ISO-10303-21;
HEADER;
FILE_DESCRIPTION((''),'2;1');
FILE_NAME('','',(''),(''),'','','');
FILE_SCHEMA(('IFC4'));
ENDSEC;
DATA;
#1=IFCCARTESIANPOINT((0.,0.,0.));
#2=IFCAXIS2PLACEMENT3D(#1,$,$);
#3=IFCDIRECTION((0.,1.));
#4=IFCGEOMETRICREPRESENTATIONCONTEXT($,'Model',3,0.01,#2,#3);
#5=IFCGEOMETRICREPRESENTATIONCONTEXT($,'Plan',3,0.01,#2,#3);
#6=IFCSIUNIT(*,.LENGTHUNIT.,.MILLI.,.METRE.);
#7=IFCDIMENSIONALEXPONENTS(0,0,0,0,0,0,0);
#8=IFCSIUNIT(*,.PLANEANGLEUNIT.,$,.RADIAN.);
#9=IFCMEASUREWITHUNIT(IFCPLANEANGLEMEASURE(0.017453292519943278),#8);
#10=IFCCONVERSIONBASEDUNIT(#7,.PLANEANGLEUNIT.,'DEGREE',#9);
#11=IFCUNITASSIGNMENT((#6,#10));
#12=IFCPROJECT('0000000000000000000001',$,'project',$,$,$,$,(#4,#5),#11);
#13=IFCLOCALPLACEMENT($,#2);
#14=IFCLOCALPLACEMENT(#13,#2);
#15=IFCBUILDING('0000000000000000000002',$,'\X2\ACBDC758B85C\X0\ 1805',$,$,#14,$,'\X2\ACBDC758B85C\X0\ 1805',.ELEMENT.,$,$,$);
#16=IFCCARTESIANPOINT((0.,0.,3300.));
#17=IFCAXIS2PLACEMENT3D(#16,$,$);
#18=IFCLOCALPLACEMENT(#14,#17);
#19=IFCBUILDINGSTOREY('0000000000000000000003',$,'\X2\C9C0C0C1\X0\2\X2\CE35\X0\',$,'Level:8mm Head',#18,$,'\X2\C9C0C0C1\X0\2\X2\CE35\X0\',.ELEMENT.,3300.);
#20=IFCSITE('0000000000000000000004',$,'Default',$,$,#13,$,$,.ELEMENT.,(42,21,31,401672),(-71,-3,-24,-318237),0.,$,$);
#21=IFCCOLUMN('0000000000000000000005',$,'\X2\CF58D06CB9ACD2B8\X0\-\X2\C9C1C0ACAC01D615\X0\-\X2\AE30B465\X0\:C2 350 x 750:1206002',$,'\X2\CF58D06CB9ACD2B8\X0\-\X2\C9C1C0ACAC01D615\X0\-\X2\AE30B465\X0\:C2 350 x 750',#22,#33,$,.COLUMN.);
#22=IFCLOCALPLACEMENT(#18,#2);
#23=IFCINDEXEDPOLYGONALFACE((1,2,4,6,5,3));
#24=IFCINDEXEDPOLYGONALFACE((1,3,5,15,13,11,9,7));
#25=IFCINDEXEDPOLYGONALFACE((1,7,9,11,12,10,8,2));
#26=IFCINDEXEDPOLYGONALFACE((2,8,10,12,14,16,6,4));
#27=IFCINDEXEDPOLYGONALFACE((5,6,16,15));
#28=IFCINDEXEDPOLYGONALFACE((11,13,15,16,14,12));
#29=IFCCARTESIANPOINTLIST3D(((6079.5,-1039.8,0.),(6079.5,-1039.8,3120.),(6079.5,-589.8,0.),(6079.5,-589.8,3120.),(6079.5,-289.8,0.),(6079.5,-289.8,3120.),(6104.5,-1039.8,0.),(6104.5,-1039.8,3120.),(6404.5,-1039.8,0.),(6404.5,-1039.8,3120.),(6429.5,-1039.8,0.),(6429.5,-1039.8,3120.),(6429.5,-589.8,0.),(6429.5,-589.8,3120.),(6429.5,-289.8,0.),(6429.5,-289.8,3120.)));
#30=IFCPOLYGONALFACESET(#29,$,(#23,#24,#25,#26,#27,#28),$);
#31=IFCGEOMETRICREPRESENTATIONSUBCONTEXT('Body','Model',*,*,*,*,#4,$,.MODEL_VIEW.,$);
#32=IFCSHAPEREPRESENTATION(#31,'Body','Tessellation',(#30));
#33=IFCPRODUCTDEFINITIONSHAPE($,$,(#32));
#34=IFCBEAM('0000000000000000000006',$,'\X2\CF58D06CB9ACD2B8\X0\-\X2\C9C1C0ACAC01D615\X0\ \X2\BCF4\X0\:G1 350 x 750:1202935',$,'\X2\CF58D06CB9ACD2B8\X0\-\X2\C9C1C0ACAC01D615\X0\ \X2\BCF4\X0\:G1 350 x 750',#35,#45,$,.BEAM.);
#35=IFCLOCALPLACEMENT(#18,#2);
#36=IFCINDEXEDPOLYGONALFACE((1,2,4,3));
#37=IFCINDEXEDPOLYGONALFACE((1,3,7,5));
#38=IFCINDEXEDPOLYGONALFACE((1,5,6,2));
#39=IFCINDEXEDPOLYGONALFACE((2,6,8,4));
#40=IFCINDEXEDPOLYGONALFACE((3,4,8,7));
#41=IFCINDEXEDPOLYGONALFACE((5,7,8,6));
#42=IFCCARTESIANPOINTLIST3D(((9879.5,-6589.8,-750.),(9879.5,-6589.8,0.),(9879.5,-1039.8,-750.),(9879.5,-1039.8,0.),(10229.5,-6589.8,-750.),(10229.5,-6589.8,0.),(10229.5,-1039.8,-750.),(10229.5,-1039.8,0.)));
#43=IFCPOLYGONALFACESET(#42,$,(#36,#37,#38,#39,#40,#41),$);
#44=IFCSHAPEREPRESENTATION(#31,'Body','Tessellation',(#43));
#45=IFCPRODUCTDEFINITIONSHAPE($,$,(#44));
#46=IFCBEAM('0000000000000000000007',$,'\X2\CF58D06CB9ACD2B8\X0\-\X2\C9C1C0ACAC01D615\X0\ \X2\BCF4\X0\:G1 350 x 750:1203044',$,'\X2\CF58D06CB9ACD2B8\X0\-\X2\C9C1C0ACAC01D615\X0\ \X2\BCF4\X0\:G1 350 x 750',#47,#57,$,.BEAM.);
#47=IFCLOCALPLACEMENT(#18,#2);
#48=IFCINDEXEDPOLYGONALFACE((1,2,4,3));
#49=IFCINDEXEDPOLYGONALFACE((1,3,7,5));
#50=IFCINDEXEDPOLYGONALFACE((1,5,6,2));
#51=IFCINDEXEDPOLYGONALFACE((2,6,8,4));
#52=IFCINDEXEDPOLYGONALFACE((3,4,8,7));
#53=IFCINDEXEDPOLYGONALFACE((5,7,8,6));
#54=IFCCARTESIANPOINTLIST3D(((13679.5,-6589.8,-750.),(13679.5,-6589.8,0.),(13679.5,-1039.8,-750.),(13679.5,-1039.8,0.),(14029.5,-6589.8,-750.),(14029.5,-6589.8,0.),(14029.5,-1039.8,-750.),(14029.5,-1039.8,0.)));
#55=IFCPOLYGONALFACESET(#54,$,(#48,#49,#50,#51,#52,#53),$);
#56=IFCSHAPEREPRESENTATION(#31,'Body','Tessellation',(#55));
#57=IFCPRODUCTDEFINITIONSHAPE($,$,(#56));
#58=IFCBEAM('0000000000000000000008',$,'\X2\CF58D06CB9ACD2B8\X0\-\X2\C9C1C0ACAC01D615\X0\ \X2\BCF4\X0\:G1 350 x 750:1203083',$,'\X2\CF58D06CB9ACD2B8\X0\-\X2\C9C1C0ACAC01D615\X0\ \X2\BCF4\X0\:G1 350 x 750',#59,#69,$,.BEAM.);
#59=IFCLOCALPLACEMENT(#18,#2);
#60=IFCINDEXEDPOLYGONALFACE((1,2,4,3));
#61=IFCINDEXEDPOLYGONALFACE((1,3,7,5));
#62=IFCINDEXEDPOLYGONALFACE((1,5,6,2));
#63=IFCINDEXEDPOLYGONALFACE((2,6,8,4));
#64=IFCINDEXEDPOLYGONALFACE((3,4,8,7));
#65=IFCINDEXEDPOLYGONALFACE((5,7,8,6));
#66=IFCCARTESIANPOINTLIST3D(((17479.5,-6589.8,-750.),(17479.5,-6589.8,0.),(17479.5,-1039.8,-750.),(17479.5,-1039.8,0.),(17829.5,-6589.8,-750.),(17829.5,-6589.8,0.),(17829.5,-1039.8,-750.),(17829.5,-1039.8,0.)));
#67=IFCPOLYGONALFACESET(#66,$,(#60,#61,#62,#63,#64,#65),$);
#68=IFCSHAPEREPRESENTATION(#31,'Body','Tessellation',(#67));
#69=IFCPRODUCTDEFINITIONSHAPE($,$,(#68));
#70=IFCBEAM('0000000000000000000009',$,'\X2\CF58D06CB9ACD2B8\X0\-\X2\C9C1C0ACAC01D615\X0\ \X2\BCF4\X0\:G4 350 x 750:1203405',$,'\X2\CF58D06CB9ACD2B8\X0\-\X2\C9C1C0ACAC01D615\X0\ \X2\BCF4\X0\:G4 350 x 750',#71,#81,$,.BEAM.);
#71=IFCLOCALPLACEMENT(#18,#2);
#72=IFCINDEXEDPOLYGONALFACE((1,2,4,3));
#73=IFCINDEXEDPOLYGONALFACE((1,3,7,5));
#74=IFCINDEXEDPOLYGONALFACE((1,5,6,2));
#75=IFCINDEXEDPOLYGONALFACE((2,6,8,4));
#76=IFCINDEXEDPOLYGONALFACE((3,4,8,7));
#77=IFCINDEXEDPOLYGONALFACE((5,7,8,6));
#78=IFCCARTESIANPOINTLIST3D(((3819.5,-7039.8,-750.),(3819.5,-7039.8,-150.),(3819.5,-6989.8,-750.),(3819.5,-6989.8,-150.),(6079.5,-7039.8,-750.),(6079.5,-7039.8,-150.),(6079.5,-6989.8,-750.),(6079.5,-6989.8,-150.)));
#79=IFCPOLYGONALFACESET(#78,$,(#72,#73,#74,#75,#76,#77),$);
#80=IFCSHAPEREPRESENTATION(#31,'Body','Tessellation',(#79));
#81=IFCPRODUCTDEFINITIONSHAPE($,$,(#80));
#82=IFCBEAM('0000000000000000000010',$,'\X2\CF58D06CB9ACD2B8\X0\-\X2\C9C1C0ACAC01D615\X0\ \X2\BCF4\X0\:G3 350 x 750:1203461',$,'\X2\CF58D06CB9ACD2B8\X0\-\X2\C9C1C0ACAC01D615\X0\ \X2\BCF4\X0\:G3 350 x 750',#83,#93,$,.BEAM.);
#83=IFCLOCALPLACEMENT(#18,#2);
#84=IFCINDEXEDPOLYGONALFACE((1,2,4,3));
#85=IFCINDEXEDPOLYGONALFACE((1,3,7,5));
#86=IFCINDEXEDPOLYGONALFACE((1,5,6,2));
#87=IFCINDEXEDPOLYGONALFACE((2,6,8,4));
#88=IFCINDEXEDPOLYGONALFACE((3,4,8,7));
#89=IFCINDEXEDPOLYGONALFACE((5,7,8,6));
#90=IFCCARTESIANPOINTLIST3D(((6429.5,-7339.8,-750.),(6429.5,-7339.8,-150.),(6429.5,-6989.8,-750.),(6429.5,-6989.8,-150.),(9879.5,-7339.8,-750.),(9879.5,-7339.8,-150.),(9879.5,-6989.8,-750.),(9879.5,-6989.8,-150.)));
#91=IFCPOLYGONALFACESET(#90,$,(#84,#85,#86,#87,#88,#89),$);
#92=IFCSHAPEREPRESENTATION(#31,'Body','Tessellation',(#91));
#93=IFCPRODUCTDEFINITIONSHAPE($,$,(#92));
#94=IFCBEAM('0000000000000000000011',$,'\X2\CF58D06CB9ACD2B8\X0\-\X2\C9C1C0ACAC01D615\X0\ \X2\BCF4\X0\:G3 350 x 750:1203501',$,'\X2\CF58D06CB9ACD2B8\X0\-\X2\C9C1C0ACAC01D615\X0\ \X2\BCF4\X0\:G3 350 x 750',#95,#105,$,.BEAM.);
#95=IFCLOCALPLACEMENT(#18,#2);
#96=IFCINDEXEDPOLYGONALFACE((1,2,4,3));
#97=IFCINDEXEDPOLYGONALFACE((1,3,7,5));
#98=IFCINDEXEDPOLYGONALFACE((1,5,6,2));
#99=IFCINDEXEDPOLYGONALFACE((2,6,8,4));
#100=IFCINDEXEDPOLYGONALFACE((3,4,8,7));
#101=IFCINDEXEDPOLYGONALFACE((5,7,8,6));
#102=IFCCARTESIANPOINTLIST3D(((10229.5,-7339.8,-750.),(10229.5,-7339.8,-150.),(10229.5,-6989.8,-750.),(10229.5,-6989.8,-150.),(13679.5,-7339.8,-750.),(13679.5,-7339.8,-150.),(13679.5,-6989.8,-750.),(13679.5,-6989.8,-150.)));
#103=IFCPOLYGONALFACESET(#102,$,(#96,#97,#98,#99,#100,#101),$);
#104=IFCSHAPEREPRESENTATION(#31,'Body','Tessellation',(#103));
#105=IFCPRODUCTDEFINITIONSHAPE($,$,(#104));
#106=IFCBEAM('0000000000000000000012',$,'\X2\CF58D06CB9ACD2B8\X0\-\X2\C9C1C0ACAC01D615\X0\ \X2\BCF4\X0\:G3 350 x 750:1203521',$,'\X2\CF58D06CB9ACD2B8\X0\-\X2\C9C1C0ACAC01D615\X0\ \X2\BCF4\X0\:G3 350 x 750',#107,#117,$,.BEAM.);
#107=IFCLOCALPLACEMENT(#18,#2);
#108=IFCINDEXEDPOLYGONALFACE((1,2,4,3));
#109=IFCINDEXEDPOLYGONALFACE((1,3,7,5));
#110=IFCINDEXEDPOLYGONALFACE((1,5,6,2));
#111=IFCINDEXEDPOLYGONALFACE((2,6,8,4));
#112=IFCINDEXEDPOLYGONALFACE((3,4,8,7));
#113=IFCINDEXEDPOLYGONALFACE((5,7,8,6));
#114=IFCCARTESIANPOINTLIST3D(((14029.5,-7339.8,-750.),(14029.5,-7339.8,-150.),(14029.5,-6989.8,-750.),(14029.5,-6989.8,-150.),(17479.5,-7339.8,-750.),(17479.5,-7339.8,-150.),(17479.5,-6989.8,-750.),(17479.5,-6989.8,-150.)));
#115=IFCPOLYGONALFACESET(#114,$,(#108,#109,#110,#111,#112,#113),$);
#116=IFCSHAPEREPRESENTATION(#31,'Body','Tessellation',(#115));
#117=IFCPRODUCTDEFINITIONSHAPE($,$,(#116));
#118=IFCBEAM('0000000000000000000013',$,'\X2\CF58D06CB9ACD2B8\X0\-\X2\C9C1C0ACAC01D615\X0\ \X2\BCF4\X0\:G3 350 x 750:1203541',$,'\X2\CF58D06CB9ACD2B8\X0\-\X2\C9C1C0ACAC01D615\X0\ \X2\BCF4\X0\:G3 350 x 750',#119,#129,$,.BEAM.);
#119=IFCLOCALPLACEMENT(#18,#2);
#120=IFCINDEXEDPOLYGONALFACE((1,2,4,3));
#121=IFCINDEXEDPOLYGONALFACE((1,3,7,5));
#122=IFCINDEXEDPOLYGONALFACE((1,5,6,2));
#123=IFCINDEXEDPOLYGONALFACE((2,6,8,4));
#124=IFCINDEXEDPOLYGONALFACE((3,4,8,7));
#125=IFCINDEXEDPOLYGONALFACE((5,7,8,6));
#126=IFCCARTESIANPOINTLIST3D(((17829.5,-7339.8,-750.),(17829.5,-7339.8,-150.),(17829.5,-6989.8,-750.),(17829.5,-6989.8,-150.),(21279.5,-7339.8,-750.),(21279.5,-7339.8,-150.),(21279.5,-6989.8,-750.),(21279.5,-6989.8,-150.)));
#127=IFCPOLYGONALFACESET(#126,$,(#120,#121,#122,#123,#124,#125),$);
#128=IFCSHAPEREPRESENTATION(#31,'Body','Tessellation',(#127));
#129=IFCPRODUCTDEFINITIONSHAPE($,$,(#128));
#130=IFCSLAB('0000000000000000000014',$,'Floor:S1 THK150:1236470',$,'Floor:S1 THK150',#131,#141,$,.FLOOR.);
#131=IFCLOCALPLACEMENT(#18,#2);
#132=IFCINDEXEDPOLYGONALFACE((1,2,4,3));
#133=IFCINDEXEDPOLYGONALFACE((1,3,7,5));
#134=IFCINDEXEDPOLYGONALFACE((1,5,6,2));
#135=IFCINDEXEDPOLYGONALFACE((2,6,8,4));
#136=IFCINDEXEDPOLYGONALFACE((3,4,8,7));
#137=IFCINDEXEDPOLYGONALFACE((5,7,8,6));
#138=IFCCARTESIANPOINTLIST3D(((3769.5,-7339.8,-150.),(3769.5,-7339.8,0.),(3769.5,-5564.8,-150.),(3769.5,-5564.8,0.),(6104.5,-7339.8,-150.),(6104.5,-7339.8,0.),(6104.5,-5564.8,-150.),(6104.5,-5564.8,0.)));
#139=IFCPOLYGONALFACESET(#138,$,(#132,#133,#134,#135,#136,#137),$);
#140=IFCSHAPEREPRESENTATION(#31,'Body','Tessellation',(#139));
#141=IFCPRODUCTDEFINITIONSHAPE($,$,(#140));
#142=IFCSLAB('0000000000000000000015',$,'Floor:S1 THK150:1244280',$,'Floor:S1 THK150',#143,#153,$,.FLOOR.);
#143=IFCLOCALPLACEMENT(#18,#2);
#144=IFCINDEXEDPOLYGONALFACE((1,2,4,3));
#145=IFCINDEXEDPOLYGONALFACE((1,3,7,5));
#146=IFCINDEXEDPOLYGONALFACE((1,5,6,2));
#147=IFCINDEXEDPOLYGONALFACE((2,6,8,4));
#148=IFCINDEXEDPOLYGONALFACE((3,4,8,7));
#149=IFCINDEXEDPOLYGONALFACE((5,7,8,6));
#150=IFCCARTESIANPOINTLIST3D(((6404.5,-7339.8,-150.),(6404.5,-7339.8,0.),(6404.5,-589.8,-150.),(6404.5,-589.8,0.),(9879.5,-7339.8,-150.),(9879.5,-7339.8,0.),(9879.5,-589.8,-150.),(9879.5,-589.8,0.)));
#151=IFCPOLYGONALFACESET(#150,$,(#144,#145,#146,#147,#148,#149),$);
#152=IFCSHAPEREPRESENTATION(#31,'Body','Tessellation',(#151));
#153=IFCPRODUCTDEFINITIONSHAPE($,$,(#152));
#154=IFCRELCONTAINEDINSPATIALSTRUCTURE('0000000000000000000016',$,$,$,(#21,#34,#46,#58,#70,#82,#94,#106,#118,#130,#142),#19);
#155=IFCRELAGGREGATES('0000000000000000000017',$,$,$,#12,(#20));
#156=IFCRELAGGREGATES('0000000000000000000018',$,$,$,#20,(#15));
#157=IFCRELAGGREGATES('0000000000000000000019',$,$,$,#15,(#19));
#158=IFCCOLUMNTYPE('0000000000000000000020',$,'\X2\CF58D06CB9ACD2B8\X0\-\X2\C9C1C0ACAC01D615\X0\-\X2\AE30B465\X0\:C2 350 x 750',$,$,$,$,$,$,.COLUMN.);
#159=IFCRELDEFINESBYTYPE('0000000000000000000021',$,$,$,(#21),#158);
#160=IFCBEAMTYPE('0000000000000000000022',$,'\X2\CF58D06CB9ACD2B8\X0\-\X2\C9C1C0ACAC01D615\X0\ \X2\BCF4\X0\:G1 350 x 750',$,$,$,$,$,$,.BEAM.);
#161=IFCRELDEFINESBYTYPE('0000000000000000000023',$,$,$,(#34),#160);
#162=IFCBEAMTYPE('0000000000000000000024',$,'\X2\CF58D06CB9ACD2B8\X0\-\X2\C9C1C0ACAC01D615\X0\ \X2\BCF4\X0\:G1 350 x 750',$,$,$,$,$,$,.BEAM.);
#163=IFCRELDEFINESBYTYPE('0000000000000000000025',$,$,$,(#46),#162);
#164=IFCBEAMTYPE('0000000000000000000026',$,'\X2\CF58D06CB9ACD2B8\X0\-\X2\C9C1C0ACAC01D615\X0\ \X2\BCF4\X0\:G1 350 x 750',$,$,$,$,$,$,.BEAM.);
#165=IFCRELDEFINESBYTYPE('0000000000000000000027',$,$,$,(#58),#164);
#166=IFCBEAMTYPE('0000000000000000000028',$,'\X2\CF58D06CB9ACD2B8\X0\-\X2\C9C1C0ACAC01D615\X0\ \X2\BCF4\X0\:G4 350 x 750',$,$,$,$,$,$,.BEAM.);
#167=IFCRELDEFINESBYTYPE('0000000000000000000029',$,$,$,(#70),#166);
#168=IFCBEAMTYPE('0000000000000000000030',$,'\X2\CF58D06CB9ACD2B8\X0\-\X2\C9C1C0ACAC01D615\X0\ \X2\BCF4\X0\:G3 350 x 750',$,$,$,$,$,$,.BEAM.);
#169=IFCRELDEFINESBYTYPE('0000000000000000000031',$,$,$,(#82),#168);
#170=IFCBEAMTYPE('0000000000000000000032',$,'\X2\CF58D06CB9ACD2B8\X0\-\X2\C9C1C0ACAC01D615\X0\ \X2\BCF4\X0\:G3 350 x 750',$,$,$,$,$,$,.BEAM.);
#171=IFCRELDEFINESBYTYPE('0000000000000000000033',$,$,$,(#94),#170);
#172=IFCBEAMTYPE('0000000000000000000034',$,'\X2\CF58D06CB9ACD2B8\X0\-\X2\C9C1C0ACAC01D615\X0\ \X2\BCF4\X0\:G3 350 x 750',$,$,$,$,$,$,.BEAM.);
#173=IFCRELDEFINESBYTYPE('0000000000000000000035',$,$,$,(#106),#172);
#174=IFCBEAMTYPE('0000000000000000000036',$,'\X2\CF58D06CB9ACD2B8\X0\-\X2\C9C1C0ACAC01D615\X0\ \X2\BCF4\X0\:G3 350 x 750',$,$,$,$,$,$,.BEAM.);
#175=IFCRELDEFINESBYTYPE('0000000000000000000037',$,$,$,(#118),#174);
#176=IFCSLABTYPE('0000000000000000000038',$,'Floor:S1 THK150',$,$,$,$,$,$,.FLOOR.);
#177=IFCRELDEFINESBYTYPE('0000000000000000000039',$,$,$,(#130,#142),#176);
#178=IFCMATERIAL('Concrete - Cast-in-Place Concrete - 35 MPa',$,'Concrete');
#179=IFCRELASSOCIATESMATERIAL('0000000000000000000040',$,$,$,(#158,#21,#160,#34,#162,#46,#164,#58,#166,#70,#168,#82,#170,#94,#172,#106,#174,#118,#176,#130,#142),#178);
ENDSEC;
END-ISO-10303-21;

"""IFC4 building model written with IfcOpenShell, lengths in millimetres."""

from ifc_helpers import new_model, entity, si_unit, converted_unit, direction, frame, origin, place, context, subcontext, project, spatial, indexed_curve, outline, extrude, source, transform, mapped, material, type_object, type_shapes, element, save


model = new_model("IFC4")

# Units and contexts
model_context = context("Model", 3, precision=0.01, world=origin(), true_north=direction((0.0, 1.0)))
plan_context = context("Plan", 3, precision=0.01, world=origin(), true_north=direction((0.0, 1.0)))
body_context = subcontext(model_context, "Body", "Model", "MODEL_VIEW")
ifc_project = project(units=[si_unit("LENGTHUNIT", "METRE", prefix="MILLI"), converted_unit("PLANEANGLEUNIT", "DEGREE", entity("IfcPlaneAngleMeasure", 0.017453292519943278), si_unit("PLANEANGLEUNIT", "RADIAN"), dimensions=[0, 0, 0, 0, 0, 0, 0])], contexts=[model_context, plan_context])

# Site, building, storey
site_placement = place(None, origin())
site = spatial("IfcSite", under=ifc_project, at=site_placement, Name="Default", CompositionType="ELEMENT", RefLatitude=(42, 21, 31, 401672), RefLongitude=(-71, -3, -24, -318237), RefElevation=0.0)
building_placement = place(site_placement, origin())
building = spatial("IfcBuilding", under=site, at=building_placement, Name="경의로 1805", LongName="경의로 1805", CompositionType="ELEMENT")
storey_placement = place(building_placement, frame((0.0, 0.0, 3300.0)))
storey = spatial("IfcBuildingStorey", under=building, at=storey_placement, Name="지상2층", ObjectType="Level:8mm Head", LongName="지상2층", CompositionType="ELEMENT", Elevation=3300.0)

# Column
ifc_material_1 = material(Name="Concrete - Cast-in-Place Concrete - 35 MPa", Category="Concrete")
column_type_1 = type_object("IfcColumnType", Name="콘크리트-직사각형-기둥:C2 350 x 750", PredefinedType="COLUMN", material=ifc_material_1)
shared_shape_1 = source(origin(), body_context, "Body", "SweptSolid", [
    extrude(outline(indexed_curve([(-175.0, -450.0), (175.0, -450.0), (175.0, -150.0), (175.0, 300.0), (150.0, 300.0), (-150.0, 300.0), (-175.0, 300.0), (-175.0, -150.0), (-175.0, -450.0)], self_intersect=False)), frame((6254.5, -739.8, 3300.0), z_axis=(0.0, 0.0, 1.0), x_axis=(-1.0, 0.0, 0.0)), (0.0, 0.0, 1.0), 3120.0),
])
type_shapes(column_type_1, [shared_shape_1])
column_1_placement = place(storey_placement, frame((0.0, 0.0, -3300.0)))
element("IfcColumn", 1, at=column_1_placement, inside=storey, type_object=column_type_1, material=ifc_material_1, Name="콘크리트-직사각형-기둥:C2 350 x 750:1206002", ObjectType="콘크리트-직사각형-기둥:C2 350 x 750", PredefinedType="COLUMN", context=body_context, shape_type="MappedRepresentation", body=[
    mapped(shared_shape_1, transform((0.0, 0.0, 0.0), scale=1.0)),
])

# Beams
beam_type_1 = type_object("IfcBeamType", Name="콘크리트-직사각형 보:G1 350 x 750", PredefinedType="BEAM", material=ifc_material_1)
shared_shape_2 = source(origin(), body_context, "Body", "SweptSolid", [
    extrude(outline(indexed_curve([(-175.0, -375.0), (175.0, -375.0), (175.0, 375.0), (-175.0, 375.0), (-175.0, -375.0)], self_intersect=False)), frame((10054.5, -1039.8, 2925.0), z_axis=(0.0, -1.0, 0.0), x_axis=(-1.0, 0.0, 0.0)), (0.0, 0.0, 1.0), 5550.0),
])
type_shapes(beam_type_1, [shared_shape_2])
beam_1_placement = place(storey_placement, frame((0.0, 0.0, -3300.0)))
element("IfcBeam", 2, at=beam_1_placement, inside=storey, type_object=beam_type_1, material=ifc_material_1, Name="콘크리트-직사각형 보:G1 350 x 750:1202935", ObjectType="콘크리트-직사각형 보:G1 350 x 750", PredefinedType="BEAM", context=body_context, shape_type="MappedRepresentation", body=[
    mapped(shared_shape_2, transform((0.0, 0.0, 0.0), scale=1.0)),
])
beam_type_2 = type_object("IfcBeamType", Name="콘크리트-직사각형 보:G1 350 x 750", PredefinedType="BEAM", material=ifc_material_1)
shared_shape_3 = source(origin(), body_context, "Body", "SweptSolid", [
    extrude(outline(indexed_curve([(-175.0, -375.0), (175.0, -375.0), (175.0, 375.0), (-175.0, 375.0), (-175.0, -375.0)], self_intersect=False)), frame((13854.5, -6589.8, 2925.0), z_axis=(0.0, 1.0, 0.0), x_axis=(-1.0, 0.0, 0.0)), (0.0, 0.0, 1.0), 5550.0),
])
type_shapes(beam_type_2, [shared_shape_3])
beam_2_placement = place(storey_placement, frame((0.0, 0.0, -3300.0)))
element("IfcBeam", 3, at=beam_2_placement, inside=storey, type_object=beam_type_2, material=ifc_material_1, Name="콘크리트-직사각형 보:G1 350 x 750:1203044", ObjectType="콘크리트-직사각형 보:G1 350 x 750", PredefinedType="BEAM", context=body_context, shape_type="MappedRepresentation", body=[
    mapped(shared_shape_3, transform((0.0, 0.0, 0.0), scale=1.0)),
])
beam_type_3 = type_object("IfcBeamType", Name="콘크리트-직사각형 보:G1 350 x 750", PredefinedType="BEAM", material=ifc_material_1)
shared_shape_4 = source(origin(), body_context, "Body", "SweptSolid", [
    extrude(outline(indexed_curve([(-175.0, -375.0), (175.0, -375.0), (175.0, 375.0), (-175.0, 375.0), (-175.0, -375.0)], self_intersect=False)), frame((17654.5, -6589.8, 2925.0), z_axis=(0.0, 1.0, 0.0), x_axis=(-1.0, 0.0, 0.0)), (0.0, 0.0, 1.0), 5550.0),
])
type_shapes(beam_type_3, [shared_shape_4])
beam_3_placement = place(storey_placement, frame((0.0, 0.0, -3300.0)))
element("IfcBeam", 4, at=beam_3_placement, inside=storey, type_object=beam_type_3, material=ifc_material_1, Name="콘크리트-직사각형 보:G1 350 x 750:1203083", ObjectType="콘크리트-직사각형 보:G1 350 x 750", PredefinedType="BEAM", context=body_context, shape_type="MappedRepresentation", body=[
    mapped(shared_shape_4, transform((0.0, 0.0, 0.0), scale=1.0)),
])
beam_type_4 = type_object("IfcBeamType", Name="콘크리트-직사각형 보:G4 350 x 750", PredefinedType="BEAM", material=ifc_material_1)
shared_shape_5 = source(origin(), body_context, "Body", "SweptSolid", [
    extrude(outline(indexed_curve([(-300.0, -25.0), (300.0, -25.0), (300.0, 25.0), (-300.0, 25.0), (-300.0, -25.0)], self_intersect=False)), frame((3819.5, -7014.8, 2850.0), z_axis=(1.0, 0.0, 0.0), x_axis=(0.0, 0.0, -1.0)), (0.0, 0.0, 1.0), 2260.0),
])
type_shapes(beam_type_4, [shared_shape_5])
beam_4_placement = place(storey_placement, frame((0.0, 0.0, -3300.0)))
element("IfcBeam", 5, at=beam_4_placement, inside=storey, type_object=beam_type_4, material=ifc_material_1, Name="콘크리트-직사각형 보:G4 350 x 750:1203405", ObjectType="콘크리트-직사각형 보:G4 350 x 750", PredefinedType="BEAM", context=body_context, shape_type="MappedRepresentation", body=[
    mapped(shared_shape_5, transform((0.0, 0.0, 0.0), scale=1.0)),
])
beam_type_5 = type_object("IfcBeamType", Name="콘크리트-직사각형 보:G3 350 x 750", PredefinedType="BEAM", material=ifc_material_1)
shared_shape_6 = source(origin(), body_context, "Body", "SweptSolid", [
    extrude(outline(indexed_curve([(-300.0, -175.0), (300.0, -175.0), (300.0, 175.0), (-300.0, 175.0), (-300.0, -175.0)], self_intersect=False)), frame((6429.5, -7164.8, 2850.0), z_axis=(1.0, 0.0, 0.0), x_axis=(0.0, 0.0, -1.0)), (0.0, 0.0, 1.0), 3450.0),
])
type_shapes(beam_type_5, [shared_shape_6])
beam_5_placement = place(storey_placement, frame((0.0, 0.0, -3300.0)))
element("IfcBeam", 6, at=beam_5_placement, inside=storey, type_object=beam_type_5, material=ifc_material_1, Name="콘크리트-직사각형 보:G3 350 x 750:1203461", ObjectType="콘크리트-직사각형 보:G3 350 x 750", PredefinedType="BEAM", context=body_context, shape_type="MappedRepresentation", body=[
    mapped(shared_shape_6, transform((0.0, 0.0, 0.0), scale=1.0)),
])
beam_type_6 = type_object("IfcBeamType", Name="콘크리트-직사각형 보:G3 350 x 750", PredefinedType="BEAM", material=ifc_material_1)
shared_shape_7 = source(origin(), body_context, "Body", "SweptSolid", [
    extrude(outline(indexed_curve([(-300.0, -175.0), (300.0, -175.0), (300.0, 175.0), (-300.0, 175.0), (-300.0, -175.0)], self_intersect=False)), frame((10229.5, -7164.8, 2850.0), z_axis=(1.0, 0.0, 0.0), x_axis=(0.0, 0.0, -1.0)), (0.0, 0.0, 1.0), 3450.0),
])
type_shapes(beam_type_6, [shared_shape_7])
beam_6_placement = place(storey_placement, frame((0.0, 0.0, -3300.0)))
element("IfcBeam", 7, at=beam_6_placement, inside=storey, type_object=beam_type_6, material=ifc_material_1, Name="콘크리트-직사각형 보:G3 350 x 750:1203501", ObjectType="콘크리트-직사각형 보:G3 350 x 750", PredefinedType="BEAM", context=body_context, shape_type="MappedRepresentation", body=[
    mapped(shared_shape_7, transform((0.0, 0.0, 0.0), scale=1.0)),
])
beam_type_7 = type_object("IfcBeamType", Name="콘크리트-직사각형 보:G3 350 x 750", PredefinedType="BEAM", material=ifc_material_1)
shared_shape_8 = source(origin(), body_context, "Body", "SweptSolid", [
    extrude(outline(indexed_curve([(-300.0, -175.0), (300.0, -175.0), (300.0, 175.0), (-300.0, 175.0), (-300.0, -175.0)], self_intersect=False)), frame((14029.5, -7164.8, 2850.0), z_axis=(1.0, 0.0, 0.0), x_axis=(0.0, 0.0, -1.0)), (0.0, 0.0, 1.0), 3450.0),
])
type_shapes(beam_type_7, [shared_shape_8])
beam_7_placement = place(storey_placement, frame((0.0, 0.0, -3300.0)))
element("IfcBeam", 8, at=beam_7_placement, inside=storey, type_object=beam_type_7, material=ifc_material_1, Name="콘크리트-직사각형 보:G3 350 x 750:1203521", ObjectType="콘크리트-직사각형 보:G3 350 x 750", PredefinedType="BEAM", context=body_context, shape_type="MappedRepresentation", body=[
    mapped(shared_shape_8, transform((0.0, 0.0, 0.0), scale=1.0)),
])
beam_type_8 = type_object("IfcBeamType", Name="콘크리트-직사각형 보:G3 350 x 750", PredefinedType="BEAM", material=ifc_material_1)
shared_shape_9 = source(origin(), body_context, "Body", "SweptSolid", [
    extrude(outline(indexed_curve([(-300.0, -175.0), (300.0, -175.0), (300.0, 175.0), (-300.0, 175.0), (-300.0, -175.0)], self_intersect=False)), frame((17829.5, -7164.8, 2850.0), z_axis=(1.0, 0.0, 0.0), x_axis=(0.0, 0.0, -1.0)), (0.0, 0.0, 1.0), 3450.0),
])
type_shapes(beam_type_8, [shared_shape_9])
beam_8_placement = place(storey_placement, frame((0.0, 0.0, -3300.0)))
element("IfcBeam", 9, at=beam_8_placement, inside=storey, type_object=beam_type_8, material=ifc_material_1, Name="콘크리트-직사각형 보:G3 350 x 750:1203541", ObjectType="콘크리트-직사각형 보:G3 350 x 750", PredefinedType="BEAM", context=body_context, shape_type="MappedRepresentation", body=[
    mapped(shared_shape_9, transform((0.0, 0.0, 0.0), scale=1.0)),
])

# Slabs
slab_type_1 = type_object("IfcSlabType", Name="Floor:S1 THK150", PredefinedType="FLOOR", material=ifc_material_1)
slab_1_placement = place(storey_placement, origin())
element("IfcSlab", 10, at=slab_1_placement, inside=storey, type_object=slab_type_1, material=ifc_material_1, Name="Floor:S1 THK150:1236470", ObjectType="Floor:S1 THK150", PredefinedType="FLOOR", context=body_context, shape_type="SweptSolid", body=[
    extrude(outline(indexed_curve([(-887.5, -1167.5), (887.5, -1167.5), (887.5, 1167.5), (-887.5, 1167.5), (-887.5, -1167.5)], self_intersect=False)), frame((4937.0, -6452.3, 0.0), z_axis=(0.0, 0.0, -1.0), x_axis=(0.0, 1.0, 0.0)), (0.0, 0.0, 1.0), 150.0),
])
slab_2_placement = place(storey_placement, origin())
element("IfcSlab", 11, at=slab_2_placement, inside=storey, type_object=slab_type_1, material=ifc_material_1, Name="Floor:S1 THK150:1244280", ObjectType="Floor:S1 THK150", PredefinedType="FLOOR", context=body_context, shape_type="SweptSolid", body=[
    extrude(outline(indexed_curve([(-1737.5, -3375.0), (1737.5, -3375.0), (1737.5, 3375.0), (-1737.5, 3375.0), (-1737.5, -3375.0)], self_intersect=False)), frame((8142.0, -3964.8, 0.0), z_axis=(0.0, 0.0, -1.0), x_axis=(1.0, 0.0, 0.0)), (0.0, 0.0, 1.0), 150.0),
])

save(model, "model.ifc")
